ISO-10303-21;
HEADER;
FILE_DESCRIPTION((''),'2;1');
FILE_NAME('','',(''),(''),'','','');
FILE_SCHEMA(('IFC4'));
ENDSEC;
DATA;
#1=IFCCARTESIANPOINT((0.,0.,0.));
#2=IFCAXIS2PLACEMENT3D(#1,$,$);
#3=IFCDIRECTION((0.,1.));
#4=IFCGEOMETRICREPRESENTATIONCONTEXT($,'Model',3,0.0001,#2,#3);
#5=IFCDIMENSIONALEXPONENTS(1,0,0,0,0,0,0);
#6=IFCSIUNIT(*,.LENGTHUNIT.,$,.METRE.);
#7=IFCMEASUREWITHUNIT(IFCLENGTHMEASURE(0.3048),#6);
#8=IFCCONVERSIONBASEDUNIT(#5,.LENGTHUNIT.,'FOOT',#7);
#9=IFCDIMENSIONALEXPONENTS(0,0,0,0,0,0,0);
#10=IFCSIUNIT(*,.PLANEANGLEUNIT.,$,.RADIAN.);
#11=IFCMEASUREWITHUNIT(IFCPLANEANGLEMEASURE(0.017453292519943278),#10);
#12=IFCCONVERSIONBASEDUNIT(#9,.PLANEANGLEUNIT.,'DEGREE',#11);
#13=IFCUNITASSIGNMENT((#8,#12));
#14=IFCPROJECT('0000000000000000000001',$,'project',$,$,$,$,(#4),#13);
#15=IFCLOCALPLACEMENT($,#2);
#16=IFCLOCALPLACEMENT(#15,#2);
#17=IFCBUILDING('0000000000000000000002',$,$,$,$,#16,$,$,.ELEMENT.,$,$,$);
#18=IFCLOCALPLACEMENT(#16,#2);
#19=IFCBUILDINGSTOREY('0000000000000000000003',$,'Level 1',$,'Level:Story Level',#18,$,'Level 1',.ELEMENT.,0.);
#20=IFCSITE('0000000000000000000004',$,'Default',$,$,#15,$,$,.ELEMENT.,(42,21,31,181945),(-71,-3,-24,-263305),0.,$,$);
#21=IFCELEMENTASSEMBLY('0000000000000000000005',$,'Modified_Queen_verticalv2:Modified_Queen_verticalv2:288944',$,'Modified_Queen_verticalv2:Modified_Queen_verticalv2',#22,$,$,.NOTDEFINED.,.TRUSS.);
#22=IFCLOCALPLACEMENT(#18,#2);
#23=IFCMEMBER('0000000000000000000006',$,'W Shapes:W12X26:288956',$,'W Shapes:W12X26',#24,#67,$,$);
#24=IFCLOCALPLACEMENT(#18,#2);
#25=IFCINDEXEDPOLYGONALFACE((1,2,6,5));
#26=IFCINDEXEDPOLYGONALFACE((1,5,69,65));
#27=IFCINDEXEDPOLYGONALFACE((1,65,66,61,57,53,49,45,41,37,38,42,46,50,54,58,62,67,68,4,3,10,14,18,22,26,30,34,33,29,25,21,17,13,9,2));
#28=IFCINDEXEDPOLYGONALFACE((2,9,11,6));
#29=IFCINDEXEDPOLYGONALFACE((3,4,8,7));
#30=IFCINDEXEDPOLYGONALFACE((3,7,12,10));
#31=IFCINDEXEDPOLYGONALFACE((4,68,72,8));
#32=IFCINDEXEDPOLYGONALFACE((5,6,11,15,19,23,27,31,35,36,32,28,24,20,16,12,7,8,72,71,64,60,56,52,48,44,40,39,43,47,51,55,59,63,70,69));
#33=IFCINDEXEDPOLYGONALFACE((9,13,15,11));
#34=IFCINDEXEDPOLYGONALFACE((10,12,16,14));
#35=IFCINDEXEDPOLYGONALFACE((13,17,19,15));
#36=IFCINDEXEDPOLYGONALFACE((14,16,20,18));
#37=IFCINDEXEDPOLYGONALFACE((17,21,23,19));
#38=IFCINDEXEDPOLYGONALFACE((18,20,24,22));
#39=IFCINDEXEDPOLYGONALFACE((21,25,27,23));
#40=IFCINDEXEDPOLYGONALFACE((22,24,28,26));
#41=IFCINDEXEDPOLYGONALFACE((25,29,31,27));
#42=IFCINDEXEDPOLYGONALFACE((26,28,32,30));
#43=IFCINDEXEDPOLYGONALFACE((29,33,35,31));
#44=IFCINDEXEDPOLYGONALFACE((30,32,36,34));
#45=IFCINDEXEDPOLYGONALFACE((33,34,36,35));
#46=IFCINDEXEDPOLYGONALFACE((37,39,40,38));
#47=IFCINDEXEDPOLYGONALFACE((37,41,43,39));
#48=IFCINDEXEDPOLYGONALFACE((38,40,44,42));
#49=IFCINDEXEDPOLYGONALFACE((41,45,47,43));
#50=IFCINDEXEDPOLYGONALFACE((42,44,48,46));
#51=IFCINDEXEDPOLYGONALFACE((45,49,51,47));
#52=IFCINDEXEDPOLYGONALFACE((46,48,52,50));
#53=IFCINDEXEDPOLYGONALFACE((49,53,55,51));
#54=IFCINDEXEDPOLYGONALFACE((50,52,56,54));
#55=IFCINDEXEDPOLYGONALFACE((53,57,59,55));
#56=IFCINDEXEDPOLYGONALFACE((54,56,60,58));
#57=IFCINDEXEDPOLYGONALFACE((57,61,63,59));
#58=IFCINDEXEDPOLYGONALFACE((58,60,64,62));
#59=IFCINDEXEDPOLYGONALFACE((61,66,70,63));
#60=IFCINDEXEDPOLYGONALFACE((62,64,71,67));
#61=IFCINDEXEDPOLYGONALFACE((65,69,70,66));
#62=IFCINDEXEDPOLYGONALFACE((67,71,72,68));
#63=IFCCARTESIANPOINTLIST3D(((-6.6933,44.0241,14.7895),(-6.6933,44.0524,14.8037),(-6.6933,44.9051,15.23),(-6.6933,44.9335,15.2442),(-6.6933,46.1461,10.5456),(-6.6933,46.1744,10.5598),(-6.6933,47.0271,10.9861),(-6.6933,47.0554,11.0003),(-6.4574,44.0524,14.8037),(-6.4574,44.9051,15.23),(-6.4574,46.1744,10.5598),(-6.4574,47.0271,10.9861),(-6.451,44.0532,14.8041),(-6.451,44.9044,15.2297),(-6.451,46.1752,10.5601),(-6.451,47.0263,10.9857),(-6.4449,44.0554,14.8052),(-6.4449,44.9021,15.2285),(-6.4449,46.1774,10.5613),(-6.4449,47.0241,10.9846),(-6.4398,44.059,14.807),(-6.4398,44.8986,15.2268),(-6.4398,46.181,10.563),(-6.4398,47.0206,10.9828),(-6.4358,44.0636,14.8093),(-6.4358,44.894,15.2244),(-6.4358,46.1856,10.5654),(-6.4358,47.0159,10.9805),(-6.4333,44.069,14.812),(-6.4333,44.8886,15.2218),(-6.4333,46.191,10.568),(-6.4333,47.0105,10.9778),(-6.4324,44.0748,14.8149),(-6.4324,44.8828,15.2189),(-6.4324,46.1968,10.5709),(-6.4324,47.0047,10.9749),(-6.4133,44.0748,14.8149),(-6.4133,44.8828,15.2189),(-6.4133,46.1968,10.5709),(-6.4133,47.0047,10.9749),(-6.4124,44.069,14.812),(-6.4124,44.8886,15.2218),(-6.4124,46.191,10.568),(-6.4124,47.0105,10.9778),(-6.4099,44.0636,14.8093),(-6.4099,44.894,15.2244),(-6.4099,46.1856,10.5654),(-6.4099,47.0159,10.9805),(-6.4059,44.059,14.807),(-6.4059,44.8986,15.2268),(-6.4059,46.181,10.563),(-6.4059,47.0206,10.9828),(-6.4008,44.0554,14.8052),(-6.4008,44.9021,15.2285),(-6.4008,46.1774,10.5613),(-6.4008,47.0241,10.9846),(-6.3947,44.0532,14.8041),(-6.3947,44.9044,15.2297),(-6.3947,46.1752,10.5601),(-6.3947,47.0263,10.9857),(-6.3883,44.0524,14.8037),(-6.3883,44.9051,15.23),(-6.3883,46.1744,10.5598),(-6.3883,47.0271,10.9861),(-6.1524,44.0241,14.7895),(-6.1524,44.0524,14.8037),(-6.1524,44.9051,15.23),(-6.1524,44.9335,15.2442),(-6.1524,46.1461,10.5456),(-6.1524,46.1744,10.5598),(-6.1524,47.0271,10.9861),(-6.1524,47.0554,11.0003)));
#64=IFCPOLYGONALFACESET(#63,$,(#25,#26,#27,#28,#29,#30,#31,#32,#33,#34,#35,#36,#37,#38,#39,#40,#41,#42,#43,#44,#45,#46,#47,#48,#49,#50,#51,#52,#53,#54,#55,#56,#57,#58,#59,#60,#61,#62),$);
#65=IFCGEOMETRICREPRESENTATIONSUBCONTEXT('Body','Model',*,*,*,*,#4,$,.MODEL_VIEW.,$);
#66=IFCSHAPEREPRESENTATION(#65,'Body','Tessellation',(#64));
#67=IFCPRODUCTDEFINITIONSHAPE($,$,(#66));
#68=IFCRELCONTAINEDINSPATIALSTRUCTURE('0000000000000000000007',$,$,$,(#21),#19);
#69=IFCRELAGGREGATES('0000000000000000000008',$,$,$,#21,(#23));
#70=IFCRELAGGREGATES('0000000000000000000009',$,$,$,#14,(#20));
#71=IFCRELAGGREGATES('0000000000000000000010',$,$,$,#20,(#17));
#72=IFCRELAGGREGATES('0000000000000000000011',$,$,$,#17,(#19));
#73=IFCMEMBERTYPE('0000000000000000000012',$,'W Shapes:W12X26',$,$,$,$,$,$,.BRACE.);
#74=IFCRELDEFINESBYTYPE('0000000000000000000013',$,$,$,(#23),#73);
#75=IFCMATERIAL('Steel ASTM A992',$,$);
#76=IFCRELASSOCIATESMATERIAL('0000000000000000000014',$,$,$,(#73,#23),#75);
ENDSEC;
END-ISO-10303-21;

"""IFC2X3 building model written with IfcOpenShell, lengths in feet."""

from ifc_helpers import new_model, entity, si_unit, converted_unit, direction, frame, frame_2d, origin, place, context, subcontext, project, spatial, polyline, circle_curve, parameter, trimmed, segment, composite_curve, outline, extrude, source, transform, mapped, material, type_object, type_shapes, element, aggregate, save


model = new_model("IFC2X3")

# Units and contexts
model_context = context("Model", 3, precision=0.0001, world=origin(), true_north=direction((0.0, 1.0)))
body_context = subcontext(model_context, "Body", "Model", "MODEL_VIEW")
ifc_project = project(units=[converted_unit("LENGTHUNIT", "FOOT", entity("IfcLengthMeasure", 0.3048), si_unit("LENGTHUNIT", "METRE"), dimensions=[1, 0, 0, 0, 0, 0, 0]), converted_unit("PLANEANGLEUNIT", "DEGREE", entity("IfcPlaneAngleMeasure", 0.017453292519943278), si_unit("PLANEANGLEUNIT", "RADIAN"), dimensions=[0, 0, 0, 0, 0, 0, 0])], contexts=[model_context])

# Site, building, storey
site_placement = place(None, origin())
site = spatial("IfcSite", under=ifc_project, at=site_placement, Name="Default", CompositionType="ELEMENT", RefLatitude=(42, 21, 31, 181945), RefLongitude=(-71, -3, -24, -263305), RefElevation=0.0)
building_placement = place(site_placement, origin())
building = spatial("IfcBuilding", under=site, at=building_placement, CompositionType="ELEMENT")
storey_placement = place(building_placement, origin())
storey = spatial("IfcBuildingStorey", under=building, at=storey_placement, Name="Level 1", ObjectType="Level:Story Level", LongName="Level 1", CompositionType="ELEMENT", Elevation=0.0)

# Element assembly, member
assembly_placement = place(storey_placement, origin())
assembly = element("IfcElementAssembly", 1, at=assembly_placement, inside=storey, Name="Modified_Queen_verticalv2:Modified_Queen_verticalv2:288944", ObjectType="Modified_Queen_verticalv2:Modified_Queen_verticalv2", AssemblyPlace="NOTDEFINED", PredefinedType="TRUSS")
ifc_material = material(Name="Steel ASTM A992")
member_type_1 = type_object("IfcMemberType", Name="W Shapes:W12X26", PredefinedType="BRACE", material=ifc_material)
shared_shape_1 = source(origin(), body_context, "Body", "SweptSolid", [
    extrude(outline(composite_curve([segment(polyline([(-0.2704, -0.4767), (-0.2704, -0.5083)]), True, "CONTINUOUS"), segment(polyline([(-0.2704, -0.5083), (0.2704, -0.5083)]), True, "CONTINUOUS"), segment(polyline([(0.2704, -0.5083), (0.2704, -0.4767)]), True, "CONTINUOUS"), segment(polyline([(0.2704, -0.4767), (0.0346, -0.4767)]), True, "CONTINUOUS"), segment(trimmed(circle_curve(frame_2d((0.0346, -0.4517), x_axis=(1.0, 0.0)), 0.025), [parameter(180.0)], [parameter(270.0)], True, "PARAMETER"), False, "CONTINUOUS"), segment(polyline([(0.0096, -0.4517), (0.0096, 0.4517)]), True, "CONTINUOUS"), segment(trimmed(circle_curve(frame_2d((0.0346, 0.4517), x_axis=(1.0, 0.0)), 0.025), [parameter(90.0)], [parameter(180.0)], True, "PARAMETER"), False, "CONTINUOUS"), segment(polyline([(0.0346, 0.4767), (0.2704, 0.4767)]), True, "CONTINUOUS"), segment(polyline([(0.2704, 0.4767), (0.2704, 0.5083)]), True, "CONTINUOUS"), segment(polyline([(0.2704, 0.5083), (-0.2704, 0.5083)]), True, "CONTINUOUS"), segment(polyline([(-0.2704, 0.5083), (-0.2704, 0.4767)]), True, "CONTINUOUS"), segment(polyline([(-0.2704, 0.4767), (-0.0346, 0.4767)]), True, "CONTINUOUS"), segment(trimmed(circle_curve(frame_2d((-0.0346, 0.4517), x_axis=(1.0, 0.0)), 0.025), [parameter(360.0)], [parameter(90.0)], True, "PARAMETER"), False, "CONTINUOUS"), segment(polyline([(-0.0096, 0.4517), (-0.0096, -0.4517)]), True, "CONTINUOUS"), segment(trimmed(circle_curve(frame_2d((-0.0346, -0.4517), x_axis=(1.0, 0.0)), 0.025), [parameter(270.0)], [parameter(360.0)], True, "PARAMETER"), False, "CONTINUOUS"), segment(polyline([(-0.0346, -0.4767), (-0.2704, -0.4767)]), True, "CONTINUOUS")], self_intersect=False)), frame((-2.1152, 0.0, 0.0), z_axis=(-1.0, 0.0, 0.0), x_axis=(0.0, -1.0, 0.0)), (0.0, 0.0, -1.0), 4.7449),
])
type_shapes(member_type_1, [shared_shape_1])
member_1_placement = place(assembly_placement, frame((-6.4228, 45.4247, 13.125), z_axis=(0.0, -0.894427, -0.447214), x_axis=(0.0, 0.447214, -0.894427)))
member_1 = element("IfcMember", 2, at=member_1_placement, type_object=member_type_1, material=ifc_material, Name="W Shapes:W12X26:288956", ObjectType="W Shapes:W12X26", context=body_context, shape_type="MappedRepresentation", body=[
    mapped(shared_shape_1, transform((0.0, 0.0, 0.0), scale=1.0)),
])
aggregate(assembly, [member_1])

save(model, "model.ifc")
